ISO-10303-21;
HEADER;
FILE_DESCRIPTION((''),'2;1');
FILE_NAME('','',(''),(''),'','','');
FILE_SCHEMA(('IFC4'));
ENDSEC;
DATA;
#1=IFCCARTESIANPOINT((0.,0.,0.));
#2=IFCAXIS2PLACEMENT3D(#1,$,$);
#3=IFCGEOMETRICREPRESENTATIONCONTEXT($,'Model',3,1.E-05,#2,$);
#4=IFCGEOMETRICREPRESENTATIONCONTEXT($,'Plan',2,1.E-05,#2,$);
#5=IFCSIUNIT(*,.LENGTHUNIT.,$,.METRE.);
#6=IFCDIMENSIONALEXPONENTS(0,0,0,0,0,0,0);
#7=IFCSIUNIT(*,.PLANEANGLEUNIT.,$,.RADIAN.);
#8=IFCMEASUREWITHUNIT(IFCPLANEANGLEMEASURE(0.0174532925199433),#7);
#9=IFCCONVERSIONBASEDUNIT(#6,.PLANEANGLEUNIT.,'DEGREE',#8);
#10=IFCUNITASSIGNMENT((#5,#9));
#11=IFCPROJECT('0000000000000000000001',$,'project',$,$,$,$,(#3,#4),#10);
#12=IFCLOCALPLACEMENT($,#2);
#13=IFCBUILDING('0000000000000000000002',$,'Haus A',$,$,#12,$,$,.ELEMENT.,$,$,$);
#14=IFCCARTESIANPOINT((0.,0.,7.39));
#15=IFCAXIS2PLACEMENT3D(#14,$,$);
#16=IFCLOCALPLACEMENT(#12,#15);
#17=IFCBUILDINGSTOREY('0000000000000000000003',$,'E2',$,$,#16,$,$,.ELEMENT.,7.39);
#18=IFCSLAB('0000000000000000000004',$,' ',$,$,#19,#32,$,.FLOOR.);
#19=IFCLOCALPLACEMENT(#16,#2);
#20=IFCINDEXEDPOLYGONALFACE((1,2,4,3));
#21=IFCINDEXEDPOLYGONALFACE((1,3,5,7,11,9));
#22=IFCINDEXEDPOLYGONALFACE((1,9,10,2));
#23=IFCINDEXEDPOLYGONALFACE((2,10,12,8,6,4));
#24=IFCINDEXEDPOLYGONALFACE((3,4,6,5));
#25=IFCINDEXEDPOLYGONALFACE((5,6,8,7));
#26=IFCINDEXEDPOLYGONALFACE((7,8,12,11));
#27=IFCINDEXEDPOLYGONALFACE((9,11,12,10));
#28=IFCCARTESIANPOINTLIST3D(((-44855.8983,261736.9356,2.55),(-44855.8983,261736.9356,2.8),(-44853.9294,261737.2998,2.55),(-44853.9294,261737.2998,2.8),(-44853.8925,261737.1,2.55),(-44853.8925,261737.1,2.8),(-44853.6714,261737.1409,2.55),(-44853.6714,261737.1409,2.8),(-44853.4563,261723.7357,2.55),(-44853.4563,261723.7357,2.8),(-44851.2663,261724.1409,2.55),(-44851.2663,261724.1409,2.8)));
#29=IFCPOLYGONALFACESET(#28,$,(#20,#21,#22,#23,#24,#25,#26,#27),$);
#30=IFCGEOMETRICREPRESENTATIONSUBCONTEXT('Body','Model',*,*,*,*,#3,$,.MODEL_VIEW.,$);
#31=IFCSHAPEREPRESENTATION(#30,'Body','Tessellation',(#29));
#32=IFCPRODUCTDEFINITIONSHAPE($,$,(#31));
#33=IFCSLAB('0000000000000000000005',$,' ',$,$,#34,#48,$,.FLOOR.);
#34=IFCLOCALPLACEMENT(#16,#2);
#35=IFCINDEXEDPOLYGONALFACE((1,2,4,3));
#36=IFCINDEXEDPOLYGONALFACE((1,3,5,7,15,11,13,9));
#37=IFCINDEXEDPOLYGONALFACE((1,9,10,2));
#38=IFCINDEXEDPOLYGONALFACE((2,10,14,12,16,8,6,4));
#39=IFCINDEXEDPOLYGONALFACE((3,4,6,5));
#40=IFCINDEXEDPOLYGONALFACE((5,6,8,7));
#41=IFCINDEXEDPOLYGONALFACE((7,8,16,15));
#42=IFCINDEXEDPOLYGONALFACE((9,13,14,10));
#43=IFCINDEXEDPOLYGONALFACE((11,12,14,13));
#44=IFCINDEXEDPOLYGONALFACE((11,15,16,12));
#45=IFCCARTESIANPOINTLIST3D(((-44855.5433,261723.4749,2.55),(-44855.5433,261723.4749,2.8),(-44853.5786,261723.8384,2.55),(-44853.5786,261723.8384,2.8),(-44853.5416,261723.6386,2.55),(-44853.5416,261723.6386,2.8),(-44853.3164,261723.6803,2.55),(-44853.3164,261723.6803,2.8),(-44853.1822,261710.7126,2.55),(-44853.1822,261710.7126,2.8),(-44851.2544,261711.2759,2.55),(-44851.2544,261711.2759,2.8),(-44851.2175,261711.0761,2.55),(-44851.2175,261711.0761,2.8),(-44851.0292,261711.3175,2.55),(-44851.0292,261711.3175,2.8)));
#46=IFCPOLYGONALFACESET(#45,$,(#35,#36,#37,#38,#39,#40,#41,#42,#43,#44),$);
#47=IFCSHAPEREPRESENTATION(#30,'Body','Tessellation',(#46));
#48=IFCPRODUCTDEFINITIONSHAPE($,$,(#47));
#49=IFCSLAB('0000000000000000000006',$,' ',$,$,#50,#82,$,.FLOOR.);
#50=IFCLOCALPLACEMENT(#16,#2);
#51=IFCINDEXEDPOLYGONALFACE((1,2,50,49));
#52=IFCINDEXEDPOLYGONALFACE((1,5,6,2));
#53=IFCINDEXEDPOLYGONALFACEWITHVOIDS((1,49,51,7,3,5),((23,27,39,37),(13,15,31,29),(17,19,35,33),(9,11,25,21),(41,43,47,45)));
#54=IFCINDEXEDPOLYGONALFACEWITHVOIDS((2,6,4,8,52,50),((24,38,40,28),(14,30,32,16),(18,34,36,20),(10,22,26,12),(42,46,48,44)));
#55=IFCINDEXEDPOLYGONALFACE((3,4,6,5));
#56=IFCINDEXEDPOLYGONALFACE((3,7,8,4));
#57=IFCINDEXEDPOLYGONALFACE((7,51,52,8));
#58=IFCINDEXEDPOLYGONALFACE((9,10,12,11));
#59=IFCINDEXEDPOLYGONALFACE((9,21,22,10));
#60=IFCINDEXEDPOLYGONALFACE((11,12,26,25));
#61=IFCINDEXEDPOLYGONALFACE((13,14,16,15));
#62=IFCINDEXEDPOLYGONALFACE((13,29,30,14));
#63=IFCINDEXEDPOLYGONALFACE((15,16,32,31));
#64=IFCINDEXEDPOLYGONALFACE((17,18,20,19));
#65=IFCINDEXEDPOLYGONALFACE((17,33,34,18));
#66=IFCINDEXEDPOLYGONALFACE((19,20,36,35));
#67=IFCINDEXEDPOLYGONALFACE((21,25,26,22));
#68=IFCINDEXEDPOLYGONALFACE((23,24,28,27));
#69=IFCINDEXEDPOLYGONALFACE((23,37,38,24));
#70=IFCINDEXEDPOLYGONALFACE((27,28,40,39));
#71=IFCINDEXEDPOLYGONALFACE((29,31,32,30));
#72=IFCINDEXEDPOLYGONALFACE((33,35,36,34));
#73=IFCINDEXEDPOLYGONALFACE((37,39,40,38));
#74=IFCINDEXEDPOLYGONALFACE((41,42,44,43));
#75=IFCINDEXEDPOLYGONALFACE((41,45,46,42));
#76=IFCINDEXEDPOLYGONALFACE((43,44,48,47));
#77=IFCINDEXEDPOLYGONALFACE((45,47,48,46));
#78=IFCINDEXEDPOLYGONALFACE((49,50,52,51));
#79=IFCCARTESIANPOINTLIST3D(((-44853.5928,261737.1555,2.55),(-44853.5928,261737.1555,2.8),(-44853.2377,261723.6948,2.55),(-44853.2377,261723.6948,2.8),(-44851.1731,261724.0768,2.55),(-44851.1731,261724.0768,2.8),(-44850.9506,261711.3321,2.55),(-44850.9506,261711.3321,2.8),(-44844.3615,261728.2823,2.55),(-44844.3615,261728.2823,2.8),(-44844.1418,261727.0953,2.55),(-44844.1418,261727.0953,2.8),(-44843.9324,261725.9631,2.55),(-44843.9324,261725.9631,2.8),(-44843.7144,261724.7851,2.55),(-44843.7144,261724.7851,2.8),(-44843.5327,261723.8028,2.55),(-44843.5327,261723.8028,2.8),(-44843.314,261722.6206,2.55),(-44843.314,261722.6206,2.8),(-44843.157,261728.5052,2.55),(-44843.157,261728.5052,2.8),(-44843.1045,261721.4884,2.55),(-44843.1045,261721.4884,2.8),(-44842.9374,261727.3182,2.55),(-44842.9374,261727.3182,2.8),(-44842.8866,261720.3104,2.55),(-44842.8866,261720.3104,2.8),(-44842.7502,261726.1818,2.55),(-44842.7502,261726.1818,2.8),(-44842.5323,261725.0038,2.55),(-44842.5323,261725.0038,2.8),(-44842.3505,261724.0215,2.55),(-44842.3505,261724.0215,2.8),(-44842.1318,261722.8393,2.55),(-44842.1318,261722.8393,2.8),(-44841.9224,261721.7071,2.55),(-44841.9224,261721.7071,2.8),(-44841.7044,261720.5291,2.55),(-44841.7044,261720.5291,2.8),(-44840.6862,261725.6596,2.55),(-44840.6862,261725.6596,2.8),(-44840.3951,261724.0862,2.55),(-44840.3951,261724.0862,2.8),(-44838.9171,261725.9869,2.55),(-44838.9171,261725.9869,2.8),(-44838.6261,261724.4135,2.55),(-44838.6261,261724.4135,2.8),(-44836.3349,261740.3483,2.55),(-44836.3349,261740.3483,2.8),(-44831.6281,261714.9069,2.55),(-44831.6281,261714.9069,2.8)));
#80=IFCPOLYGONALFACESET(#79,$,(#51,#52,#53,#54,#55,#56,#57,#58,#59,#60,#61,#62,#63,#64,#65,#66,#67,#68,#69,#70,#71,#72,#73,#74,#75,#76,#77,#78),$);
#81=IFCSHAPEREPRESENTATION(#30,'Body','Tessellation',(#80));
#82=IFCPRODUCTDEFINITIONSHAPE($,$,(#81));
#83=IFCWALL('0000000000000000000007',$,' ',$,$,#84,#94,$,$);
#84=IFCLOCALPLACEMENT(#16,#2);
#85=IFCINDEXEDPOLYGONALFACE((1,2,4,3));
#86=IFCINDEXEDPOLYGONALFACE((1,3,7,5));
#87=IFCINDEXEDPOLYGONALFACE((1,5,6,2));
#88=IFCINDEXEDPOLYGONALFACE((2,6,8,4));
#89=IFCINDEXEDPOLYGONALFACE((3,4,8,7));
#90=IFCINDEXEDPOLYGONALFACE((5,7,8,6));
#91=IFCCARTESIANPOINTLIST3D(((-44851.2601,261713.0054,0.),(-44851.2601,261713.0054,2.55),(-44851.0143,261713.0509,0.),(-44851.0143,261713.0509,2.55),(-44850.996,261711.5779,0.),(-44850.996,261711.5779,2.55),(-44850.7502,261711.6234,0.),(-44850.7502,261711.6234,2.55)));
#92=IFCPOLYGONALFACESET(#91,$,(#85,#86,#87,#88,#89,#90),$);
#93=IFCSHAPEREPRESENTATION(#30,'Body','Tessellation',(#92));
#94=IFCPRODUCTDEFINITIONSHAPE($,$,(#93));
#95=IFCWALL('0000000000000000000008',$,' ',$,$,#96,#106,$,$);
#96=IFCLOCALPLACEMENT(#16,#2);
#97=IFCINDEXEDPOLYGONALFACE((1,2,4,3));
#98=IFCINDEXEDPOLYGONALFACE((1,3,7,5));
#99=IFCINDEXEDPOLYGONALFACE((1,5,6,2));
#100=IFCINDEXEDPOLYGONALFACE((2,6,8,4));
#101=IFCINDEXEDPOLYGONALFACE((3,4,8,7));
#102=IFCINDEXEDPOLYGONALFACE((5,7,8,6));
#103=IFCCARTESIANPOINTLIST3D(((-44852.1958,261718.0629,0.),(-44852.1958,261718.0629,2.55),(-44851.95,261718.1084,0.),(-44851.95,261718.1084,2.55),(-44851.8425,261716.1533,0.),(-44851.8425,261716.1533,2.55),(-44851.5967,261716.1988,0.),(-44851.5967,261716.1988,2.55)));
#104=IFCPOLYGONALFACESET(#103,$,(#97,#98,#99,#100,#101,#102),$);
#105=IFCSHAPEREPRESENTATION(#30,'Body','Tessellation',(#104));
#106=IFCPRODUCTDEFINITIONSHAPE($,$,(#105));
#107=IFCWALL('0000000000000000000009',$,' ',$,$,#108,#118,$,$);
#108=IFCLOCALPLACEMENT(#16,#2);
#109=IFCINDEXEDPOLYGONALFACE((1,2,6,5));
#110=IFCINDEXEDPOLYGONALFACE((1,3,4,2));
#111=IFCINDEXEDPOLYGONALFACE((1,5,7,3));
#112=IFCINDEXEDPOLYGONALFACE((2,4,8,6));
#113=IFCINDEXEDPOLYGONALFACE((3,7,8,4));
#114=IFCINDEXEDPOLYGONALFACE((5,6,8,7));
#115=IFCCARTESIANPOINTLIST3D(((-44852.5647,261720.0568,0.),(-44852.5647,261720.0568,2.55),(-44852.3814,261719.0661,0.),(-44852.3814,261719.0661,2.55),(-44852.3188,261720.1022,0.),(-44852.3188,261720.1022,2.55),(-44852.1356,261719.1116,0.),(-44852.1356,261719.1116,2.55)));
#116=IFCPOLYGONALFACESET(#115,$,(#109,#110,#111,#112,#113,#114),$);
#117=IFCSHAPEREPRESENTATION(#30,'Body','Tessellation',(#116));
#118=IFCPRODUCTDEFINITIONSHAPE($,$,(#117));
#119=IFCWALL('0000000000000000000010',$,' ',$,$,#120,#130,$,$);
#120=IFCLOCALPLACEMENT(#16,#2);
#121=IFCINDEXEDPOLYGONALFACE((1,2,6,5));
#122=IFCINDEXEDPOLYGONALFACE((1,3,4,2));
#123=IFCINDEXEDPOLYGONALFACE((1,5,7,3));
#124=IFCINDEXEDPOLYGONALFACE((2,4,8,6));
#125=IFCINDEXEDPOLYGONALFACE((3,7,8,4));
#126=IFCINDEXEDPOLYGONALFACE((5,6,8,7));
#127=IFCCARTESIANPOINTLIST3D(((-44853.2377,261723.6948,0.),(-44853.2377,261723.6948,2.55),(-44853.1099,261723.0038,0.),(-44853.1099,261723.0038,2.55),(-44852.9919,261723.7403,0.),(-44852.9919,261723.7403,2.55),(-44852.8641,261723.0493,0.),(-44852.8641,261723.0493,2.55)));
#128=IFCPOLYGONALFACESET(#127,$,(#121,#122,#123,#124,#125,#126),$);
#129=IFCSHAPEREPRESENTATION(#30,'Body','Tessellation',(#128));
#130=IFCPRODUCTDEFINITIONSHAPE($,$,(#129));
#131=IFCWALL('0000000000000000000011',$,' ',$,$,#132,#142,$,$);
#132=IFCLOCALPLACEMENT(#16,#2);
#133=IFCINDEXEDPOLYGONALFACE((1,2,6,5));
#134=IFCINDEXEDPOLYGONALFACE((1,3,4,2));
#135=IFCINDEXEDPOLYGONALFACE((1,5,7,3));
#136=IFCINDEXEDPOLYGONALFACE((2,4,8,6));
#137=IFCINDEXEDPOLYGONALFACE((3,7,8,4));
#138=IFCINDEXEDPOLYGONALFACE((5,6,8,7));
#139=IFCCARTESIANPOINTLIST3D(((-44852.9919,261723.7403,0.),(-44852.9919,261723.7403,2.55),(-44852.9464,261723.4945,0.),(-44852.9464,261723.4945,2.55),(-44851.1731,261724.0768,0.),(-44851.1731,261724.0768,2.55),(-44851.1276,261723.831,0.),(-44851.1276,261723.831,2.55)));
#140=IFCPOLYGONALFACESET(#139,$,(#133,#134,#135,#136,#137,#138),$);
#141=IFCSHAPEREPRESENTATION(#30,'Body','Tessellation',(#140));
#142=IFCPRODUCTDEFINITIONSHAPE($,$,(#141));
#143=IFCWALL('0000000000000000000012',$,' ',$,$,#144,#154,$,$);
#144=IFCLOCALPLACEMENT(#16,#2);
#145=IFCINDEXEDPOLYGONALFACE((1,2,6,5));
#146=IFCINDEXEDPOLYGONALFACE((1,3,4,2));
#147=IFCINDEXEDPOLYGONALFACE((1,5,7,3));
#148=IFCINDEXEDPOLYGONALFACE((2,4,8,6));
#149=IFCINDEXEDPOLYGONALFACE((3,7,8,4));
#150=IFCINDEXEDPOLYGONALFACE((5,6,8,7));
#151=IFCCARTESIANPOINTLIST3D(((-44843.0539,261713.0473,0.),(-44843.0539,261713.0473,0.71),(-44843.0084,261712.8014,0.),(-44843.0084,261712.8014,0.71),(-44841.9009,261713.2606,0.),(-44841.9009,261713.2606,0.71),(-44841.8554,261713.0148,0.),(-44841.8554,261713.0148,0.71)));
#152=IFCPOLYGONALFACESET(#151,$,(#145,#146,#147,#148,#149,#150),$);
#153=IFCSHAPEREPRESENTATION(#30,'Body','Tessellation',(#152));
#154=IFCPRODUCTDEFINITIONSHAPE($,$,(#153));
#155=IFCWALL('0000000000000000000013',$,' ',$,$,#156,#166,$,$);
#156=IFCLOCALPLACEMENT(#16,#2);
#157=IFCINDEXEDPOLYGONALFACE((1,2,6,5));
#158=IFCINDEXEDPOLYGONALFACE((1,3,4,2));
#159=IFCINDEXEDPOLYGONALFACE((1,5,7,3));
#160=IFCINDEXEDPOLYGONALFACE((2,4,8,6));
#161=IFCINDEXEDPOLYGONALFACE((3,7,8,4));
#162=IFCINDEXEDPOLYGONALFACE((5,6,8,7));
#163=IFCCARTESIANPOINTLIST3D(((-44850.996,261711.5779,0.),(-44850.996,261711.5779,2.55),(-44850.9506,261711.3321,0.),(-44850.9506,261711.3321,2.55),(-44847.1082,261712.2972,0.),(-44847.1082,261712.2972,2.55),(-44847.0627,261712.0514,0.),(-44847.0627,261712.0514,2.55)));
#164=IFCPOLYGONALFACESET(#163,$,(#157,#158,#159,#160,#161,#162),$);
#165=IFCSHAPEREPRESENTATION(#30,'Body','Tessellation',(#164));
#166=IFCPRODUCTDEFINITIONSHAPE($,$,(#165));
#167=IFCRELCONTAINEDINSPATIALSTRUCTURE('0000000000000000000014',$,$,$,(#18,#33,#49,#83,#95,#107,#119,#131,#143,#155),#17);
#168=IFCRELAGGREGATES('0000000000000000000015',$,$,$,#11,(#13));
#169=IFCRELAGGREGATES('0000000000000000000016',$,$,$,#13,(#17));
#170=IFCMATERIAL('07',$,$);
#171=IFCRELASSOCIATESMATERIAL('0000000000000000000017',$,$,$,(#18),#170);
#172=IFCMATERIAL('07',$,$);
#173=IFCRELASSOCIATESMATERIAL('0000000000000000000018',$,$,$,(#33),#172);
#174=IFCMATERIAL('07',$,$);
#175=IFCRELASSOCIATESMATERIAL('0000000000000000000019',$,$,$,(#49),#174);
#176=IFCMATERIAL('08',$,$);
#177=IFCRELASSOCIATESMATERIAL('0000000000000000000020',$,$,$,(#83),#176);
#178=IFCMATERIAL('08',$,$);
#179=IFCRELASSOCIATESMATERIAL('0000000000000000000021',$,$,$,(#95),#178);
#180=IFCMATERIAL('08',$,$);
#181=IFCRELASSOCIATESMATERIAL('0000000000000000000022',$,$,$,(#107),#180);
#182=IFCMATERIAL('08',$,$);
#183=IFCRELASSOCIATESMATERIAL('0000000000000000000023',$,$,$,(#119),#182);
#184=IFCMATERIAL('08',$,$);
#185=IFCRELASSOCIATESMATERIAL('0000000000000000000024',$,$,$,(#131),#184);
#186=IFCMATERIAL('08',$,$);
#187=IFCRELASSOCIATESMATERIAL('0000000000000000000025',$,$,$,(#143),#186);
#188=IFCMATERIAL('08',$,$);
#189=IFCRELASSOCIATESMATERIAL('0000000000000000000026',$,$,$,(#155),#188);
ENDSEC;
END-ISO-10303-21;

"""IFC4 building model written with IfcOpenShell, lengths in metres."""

from ifc_helpers import new_model, entity, si_unit, converted_unit, frame, frame_2d, origin, origin_with_axes, place, context, subcontext, project, spatial, polyline, rectangle, outline, extrude, material, element, save


model = new_model("IFC4")

# Units and contexts
model_context = context("Model", 3, precision=1e-05, world=origin())
plan_context = context("Plan", 2, precision=1e-05, world=origin())
body_context = subcontext(model_context, "Body", "Model", "MODEL_VIEW")
ifc_project = project(units=[si_unit("LENGTHUNIT", "METRE"), converted_unit("PLANEANGLEUNIT", "DEGREE", entity("IfcPlaneAngleMeasure", 0.0174532925199433), si_unit("PLANEANGLEUNIT", "RADIAN"), dimensions=[0, 0, 0, 0, 0, 0, 0])], contexts=[model_context, plan_context])

# Building, storey
building_placement = place(None, origin())
building = spatial("IfcBuilding", under=ifc_project, at=building_placement, Name="Haus A", CompositionType="ELEMENT")
storey_placement = place(building_placement, frame((0.0, 0.0, 7.39)))
storey = spatial("IfcBuildingStorey", under=building, at=storey_placement, Name="E2", CompositionType="ELEMENT", Elevation=7.39)

# Slabs
ifc_material_1 = material(Name="07")
slab_1_placement = place(storey_placement, frame((-44855.8983, 261723.7357, 2.55)))
element("IfcSlab", 1, at=slab_1_placement, inside=storey, material=ifc_material_1, Name=" ", PredefinedType="FLOOR", context=body_context, shape_type="SweptSolid", body=[
    extrude(outline(polyline([(0.0, 13.1998), (2.4421, 0.0), (4.632, 0.4051), (2.2269, 13.4052), (2.0058, 13.3643), (1.9689, 13.5641), (0.0, 13.1998)])), origin_with_axes(), (0.0, 0.0, 1.0), 0.25),
])
ifc_material_2 = material(Name="07")
slab_2_placement = place(storey_placement, frame((-44855.5433, 261710.7126, 2.55)))
element("IfcSlab", 2, at=slab_2_placement, inside=storey, material=ifc_material_2, Name=" ", PredefinedType="FLOOR", context=body_context, shape_type="SweptSolid", body=[
    extrude(outline(polyline([(1.9647, 13.1258), (0.0, 12.7623), (2.3611, 0.0), (4.3258, 0.3635), (4.2889, 0.5633), (4.5141, 0.605), (2.2269, 12.9677), (2.0017, 12.926), (1.9647, 13.1258)])), origin_with_axes(), (0.0, 0.0, 1.0), 0.25),
])

# Slab, openings
ifc_material_3 = material(Name="07")
slab_3_placement = place(storey_placement, frame((-44853.5928, 261711.3321, 2.55)))
slab_3 = element("IfcSlab", 3, at=slab_3_placement, inside=storey, material=ifc_material_3, Name=" ", PredefinedType="FLOOR", context=body_context, shape_type="SweptSolid", body=[
    extrude(outline(polyline([(0.0, 25.8234), (2.4196, 12.7447), (0.355, 12.3627), (2.6422, 0.0), (21.9647, 3.5748), (17.2579, 29.0162), (0.0, 25.8234)])), origin_with_axes(), (0.0, 0.0, 1.0), 0.25),
])
opening_1_placement = place(slab_3_placement, frame((9.2313, 15.7632, 0.0)))
element("IfcOpeningStandardCase", 4, at=opening_1_placement, cuts=slab_3, PredefinedType="OPENING", context=body_context, shape_type="SweptSolid", body=[
    extrude(rectangle(XDim=1.2071, YDim=1.2249, at=frame_2d((0.0, 0.0), x_axis=(0.18192, -0.983313))), frame((0.712, 0.7049, 0.0), z_axis=(0.0, 0.0, 1.0), x_axis=(1.0, 0.0, 0.0)), (0.0, 0.0, 1.0), 0.25),
])
opening_2_placement = place(slab_3_placement, frame((9.6604, 13.453, 0.0)))
element("IfcOpeningStandardCase", 5, at=opening_2_placement, cuts=slab_3, PredefinedType="OPENING", context=body_context, shape_type="SweptSolid", body=[
    extrude(rectangle(XDim=1.198, YDim=1.2022, at=frame_2d((0.0, 0.0), x_axis=(0.18192, -0.983313))), frame((0.7, 0.6984, 0.0), z_axis=(0.0, 0.0, 1.0), x_axis=(1.0, 0.0, 0.0)), (0.0, 0.0, 1.0), 0.25),
])
opening_3_placement = place(slab_3_placement, frame((10.0601, 11.2885, 0.0)))
element("IfcOpeningStandardCase", 6, at=opening_3_placement, cuts=slab_3, PredefinedType="OPENING", context=body_context, shape_type="SweptSolid", body=[
    extrude(rectangle(XDim=1.2022, YDim=1.2022, at=frame_2d((0.0, 0.0), x_axis=(-0.983313, -0.18192))), frame((0.7004, 0.7004, 0.0), z_axis=(0.0, 0.0, 1.0), x_axis=(1.0, 0.0, 0.0)), (0.0, 0.0, 1.0), 0.25),
])
opening_4_placement = place(slab_3_placement, frame((10.4882, 8.9783, 0.0)))
element("IfcOpeningStandardCase", 7, at=opening_4_placement, cuts=slab_3, PredefinedType="OPENING", context=body_context, shape_type="SweptSolid", body=[
    extrude(rectangle(XDim=1.198, YDim=1.2022, at=frame_2d((0.0, 0.0), x_axis=(0.18192, -0.983313))), frame((0.7, 0.6984, 0.0), z_axis=(0.0, 0.0, 1.0), x_axis=(1.0, 0.0, 0.0)), (0.0, 0.0, 1.0), 0.25),
])
opening_5_placement = place(slab_3_placement, frame((12.9065, 12.7541, 0.0)))
element("IfcOpeningStandardCase", 8, at=opening_5_placement, cuts=slab_3, PredefinedType="OPENING", context=body_context, shape_type="SweptSolid", body=[
    extrude(rectangle(XDim=1.6001, YDim=1.7991, at=frame_2d((0.0, 0.0), x_axis=(-0.18192, 0.983313))), frame((1.0301, 0.9504, 0.0), z_axis=(0.0, 0.0, 1.0), x_axis=(1.0, 0.0, 0.0)), (0.0, 0.0, 1.0), 0.25),
])

# Walls
ifc_material_4 = material(Name="08")
wall_1_placement = place(storey_placement, frame((-44851.2601, 261713.0054, 0.0), z_axis=(0.0, 0.0, 1.0), x_axis=(0.18192, -0.983313, 0.0)))
element("IfcWall", 9, at=wall_1_placement, inside=storey, material=ifc_material_4, Name=" ", context=body_context, shape_type="SweptSolid", body=[
    extrude(rectangle(XDim=1.4517, YDim=0.25, at=frame_2d((0.7259, 0.125), x_axis=(1.0, 0.0))), origin_with_axes(), (0.0, 0.0, 1.0), 2.55),
])
ifc_material_5 = material(Name="08")
wall_2_placement = place(storey_placement, frame((-44852.1958, 261718.0629, 0.0), z_axis=(0.0, 0.0, 1.0), x_axis=(0.18192, -0.983313, 0.0)))
element("IfcWall", 10, at=wall_2_placement, inside=storey, material=ifc_material_5, Name=" ", context=body_context, shape_type="SweptSolid", body=[
    extrude(rectangle(XDim=1.942, YDim=0.25, at=frame_2d((0.971, 0.125), x_axis=(1.0, 0.0))), origin_with_axes(), (0.0, 0.0, 1.0), 2.55),
])
ifc_material_6 = material(Name="08")
wall_3_placement = place(storey_placement, frame((-44852.5647, 261720.0568, 0.0), z_axis=(0.0, 0.0, 1.0), x_axis=(0.18192, -0.983313, 0.0)))
element("IfcWall", 11, at=wall_3_placement, inside=storey, material=ifc_material_6, Name=" ", context=body_context, shape_type="SweptSolid", body=[
    extrude(rectangle(XDim=1.0075, YDim=0.25, at=frame_2d((0.5037, 0.125), x_axis=(1.0, 0.0))), origin_with_axes(), (0.0, 0.0, 1.0), 2.55),
])
ifc_material_7 = material(Name="08")
wall_4_placement = place(storey_placement, frame((-44853.2377, 261723.6948, 0.0), z_axis=(0.0, 0.0, 1.0), x_axis=(0.18192, -0.983313, 0.0)))
element("IfcWall", 12, at=wall_4_placement, inside=storey, material=ifc_material_7, Name=" ", context=body_context, shape_type="SweptSolid", body=[
    extrude(rectangle(XDim=0.7027, YDim=0.25, at=frame_2d((0.3514, 0.125), x_axis=(1.0, 0.0))), origin_with_axes(), (0.0, 0.0, 1.0), 2.55),
])
ifc_material_8 = material(Name="08")
wall_5_placement = place(storey_placement, frame((-44851.1731, 261724.0768, 0.0), z_axis=(0.0, 0.0, 1.0), x_axis=(-0.983313, -0.18192, 0.0)))
element("IfcWall", 13, at=wall_5_placement, inside=storey, material=ifc_material_8, Name=" ", context=body_context, shape_type="SweptSolid", body=[
    extrude(rectangle(XDim=1.8497, YDim=0.25, at=frame_2d((0.9248, 0.125), x_axis=(1.0, 0.0))), origin_with_axes(), (0.0, 0.0, 1.0), 2.55),
])
ifc_material_9 = material(Name="08")
wall_6_placement = place(storey_placement, frame((-44841.9009, 261713.2606, 0.0), z_axis=(0.0, 0.0, 1.0), x_axis=(-0.983313, -0.18192, 0.0)))
element("IfcWall", 14, at=wall_6_placement, inside=storey, material=ifc_material_9, Name=" ", context=body_context, shape_type="SweptSolid", body=[
    extrude(rectangle(XDim=1.1726, YDim=0.25, at=frame_2d((0.5863, 0.125), x_axis=(1.0, 0.0))), origin_with_axes(), (0.0, 0.0, 1.0), 0.71),
])
ifc_material_10 = material(Name="08")
wall_7_placement = place(storey_placement, frame((-44850.9506, 261711.3321, 0.0), z_axis=(0.0, 0.0, 1.0), x_axis=(0.983313, 0.18192, 0.0)))
element("IfcWall", 15, at=wall_7_placement, inside=storey, material=ifc_material_10, Name=" ", context=body_context, shape_type="SweptSolid", body=[
    extrude(rectangle(XDim=3.9538, YDim=0.25, at=frame_2d((1.9769, 0.125), x_axis=(1.0, 0.0))), origin_with_axes(), (0.0, 0.0, 1.0), 2.55),
])

save(model, "model.ifc")
